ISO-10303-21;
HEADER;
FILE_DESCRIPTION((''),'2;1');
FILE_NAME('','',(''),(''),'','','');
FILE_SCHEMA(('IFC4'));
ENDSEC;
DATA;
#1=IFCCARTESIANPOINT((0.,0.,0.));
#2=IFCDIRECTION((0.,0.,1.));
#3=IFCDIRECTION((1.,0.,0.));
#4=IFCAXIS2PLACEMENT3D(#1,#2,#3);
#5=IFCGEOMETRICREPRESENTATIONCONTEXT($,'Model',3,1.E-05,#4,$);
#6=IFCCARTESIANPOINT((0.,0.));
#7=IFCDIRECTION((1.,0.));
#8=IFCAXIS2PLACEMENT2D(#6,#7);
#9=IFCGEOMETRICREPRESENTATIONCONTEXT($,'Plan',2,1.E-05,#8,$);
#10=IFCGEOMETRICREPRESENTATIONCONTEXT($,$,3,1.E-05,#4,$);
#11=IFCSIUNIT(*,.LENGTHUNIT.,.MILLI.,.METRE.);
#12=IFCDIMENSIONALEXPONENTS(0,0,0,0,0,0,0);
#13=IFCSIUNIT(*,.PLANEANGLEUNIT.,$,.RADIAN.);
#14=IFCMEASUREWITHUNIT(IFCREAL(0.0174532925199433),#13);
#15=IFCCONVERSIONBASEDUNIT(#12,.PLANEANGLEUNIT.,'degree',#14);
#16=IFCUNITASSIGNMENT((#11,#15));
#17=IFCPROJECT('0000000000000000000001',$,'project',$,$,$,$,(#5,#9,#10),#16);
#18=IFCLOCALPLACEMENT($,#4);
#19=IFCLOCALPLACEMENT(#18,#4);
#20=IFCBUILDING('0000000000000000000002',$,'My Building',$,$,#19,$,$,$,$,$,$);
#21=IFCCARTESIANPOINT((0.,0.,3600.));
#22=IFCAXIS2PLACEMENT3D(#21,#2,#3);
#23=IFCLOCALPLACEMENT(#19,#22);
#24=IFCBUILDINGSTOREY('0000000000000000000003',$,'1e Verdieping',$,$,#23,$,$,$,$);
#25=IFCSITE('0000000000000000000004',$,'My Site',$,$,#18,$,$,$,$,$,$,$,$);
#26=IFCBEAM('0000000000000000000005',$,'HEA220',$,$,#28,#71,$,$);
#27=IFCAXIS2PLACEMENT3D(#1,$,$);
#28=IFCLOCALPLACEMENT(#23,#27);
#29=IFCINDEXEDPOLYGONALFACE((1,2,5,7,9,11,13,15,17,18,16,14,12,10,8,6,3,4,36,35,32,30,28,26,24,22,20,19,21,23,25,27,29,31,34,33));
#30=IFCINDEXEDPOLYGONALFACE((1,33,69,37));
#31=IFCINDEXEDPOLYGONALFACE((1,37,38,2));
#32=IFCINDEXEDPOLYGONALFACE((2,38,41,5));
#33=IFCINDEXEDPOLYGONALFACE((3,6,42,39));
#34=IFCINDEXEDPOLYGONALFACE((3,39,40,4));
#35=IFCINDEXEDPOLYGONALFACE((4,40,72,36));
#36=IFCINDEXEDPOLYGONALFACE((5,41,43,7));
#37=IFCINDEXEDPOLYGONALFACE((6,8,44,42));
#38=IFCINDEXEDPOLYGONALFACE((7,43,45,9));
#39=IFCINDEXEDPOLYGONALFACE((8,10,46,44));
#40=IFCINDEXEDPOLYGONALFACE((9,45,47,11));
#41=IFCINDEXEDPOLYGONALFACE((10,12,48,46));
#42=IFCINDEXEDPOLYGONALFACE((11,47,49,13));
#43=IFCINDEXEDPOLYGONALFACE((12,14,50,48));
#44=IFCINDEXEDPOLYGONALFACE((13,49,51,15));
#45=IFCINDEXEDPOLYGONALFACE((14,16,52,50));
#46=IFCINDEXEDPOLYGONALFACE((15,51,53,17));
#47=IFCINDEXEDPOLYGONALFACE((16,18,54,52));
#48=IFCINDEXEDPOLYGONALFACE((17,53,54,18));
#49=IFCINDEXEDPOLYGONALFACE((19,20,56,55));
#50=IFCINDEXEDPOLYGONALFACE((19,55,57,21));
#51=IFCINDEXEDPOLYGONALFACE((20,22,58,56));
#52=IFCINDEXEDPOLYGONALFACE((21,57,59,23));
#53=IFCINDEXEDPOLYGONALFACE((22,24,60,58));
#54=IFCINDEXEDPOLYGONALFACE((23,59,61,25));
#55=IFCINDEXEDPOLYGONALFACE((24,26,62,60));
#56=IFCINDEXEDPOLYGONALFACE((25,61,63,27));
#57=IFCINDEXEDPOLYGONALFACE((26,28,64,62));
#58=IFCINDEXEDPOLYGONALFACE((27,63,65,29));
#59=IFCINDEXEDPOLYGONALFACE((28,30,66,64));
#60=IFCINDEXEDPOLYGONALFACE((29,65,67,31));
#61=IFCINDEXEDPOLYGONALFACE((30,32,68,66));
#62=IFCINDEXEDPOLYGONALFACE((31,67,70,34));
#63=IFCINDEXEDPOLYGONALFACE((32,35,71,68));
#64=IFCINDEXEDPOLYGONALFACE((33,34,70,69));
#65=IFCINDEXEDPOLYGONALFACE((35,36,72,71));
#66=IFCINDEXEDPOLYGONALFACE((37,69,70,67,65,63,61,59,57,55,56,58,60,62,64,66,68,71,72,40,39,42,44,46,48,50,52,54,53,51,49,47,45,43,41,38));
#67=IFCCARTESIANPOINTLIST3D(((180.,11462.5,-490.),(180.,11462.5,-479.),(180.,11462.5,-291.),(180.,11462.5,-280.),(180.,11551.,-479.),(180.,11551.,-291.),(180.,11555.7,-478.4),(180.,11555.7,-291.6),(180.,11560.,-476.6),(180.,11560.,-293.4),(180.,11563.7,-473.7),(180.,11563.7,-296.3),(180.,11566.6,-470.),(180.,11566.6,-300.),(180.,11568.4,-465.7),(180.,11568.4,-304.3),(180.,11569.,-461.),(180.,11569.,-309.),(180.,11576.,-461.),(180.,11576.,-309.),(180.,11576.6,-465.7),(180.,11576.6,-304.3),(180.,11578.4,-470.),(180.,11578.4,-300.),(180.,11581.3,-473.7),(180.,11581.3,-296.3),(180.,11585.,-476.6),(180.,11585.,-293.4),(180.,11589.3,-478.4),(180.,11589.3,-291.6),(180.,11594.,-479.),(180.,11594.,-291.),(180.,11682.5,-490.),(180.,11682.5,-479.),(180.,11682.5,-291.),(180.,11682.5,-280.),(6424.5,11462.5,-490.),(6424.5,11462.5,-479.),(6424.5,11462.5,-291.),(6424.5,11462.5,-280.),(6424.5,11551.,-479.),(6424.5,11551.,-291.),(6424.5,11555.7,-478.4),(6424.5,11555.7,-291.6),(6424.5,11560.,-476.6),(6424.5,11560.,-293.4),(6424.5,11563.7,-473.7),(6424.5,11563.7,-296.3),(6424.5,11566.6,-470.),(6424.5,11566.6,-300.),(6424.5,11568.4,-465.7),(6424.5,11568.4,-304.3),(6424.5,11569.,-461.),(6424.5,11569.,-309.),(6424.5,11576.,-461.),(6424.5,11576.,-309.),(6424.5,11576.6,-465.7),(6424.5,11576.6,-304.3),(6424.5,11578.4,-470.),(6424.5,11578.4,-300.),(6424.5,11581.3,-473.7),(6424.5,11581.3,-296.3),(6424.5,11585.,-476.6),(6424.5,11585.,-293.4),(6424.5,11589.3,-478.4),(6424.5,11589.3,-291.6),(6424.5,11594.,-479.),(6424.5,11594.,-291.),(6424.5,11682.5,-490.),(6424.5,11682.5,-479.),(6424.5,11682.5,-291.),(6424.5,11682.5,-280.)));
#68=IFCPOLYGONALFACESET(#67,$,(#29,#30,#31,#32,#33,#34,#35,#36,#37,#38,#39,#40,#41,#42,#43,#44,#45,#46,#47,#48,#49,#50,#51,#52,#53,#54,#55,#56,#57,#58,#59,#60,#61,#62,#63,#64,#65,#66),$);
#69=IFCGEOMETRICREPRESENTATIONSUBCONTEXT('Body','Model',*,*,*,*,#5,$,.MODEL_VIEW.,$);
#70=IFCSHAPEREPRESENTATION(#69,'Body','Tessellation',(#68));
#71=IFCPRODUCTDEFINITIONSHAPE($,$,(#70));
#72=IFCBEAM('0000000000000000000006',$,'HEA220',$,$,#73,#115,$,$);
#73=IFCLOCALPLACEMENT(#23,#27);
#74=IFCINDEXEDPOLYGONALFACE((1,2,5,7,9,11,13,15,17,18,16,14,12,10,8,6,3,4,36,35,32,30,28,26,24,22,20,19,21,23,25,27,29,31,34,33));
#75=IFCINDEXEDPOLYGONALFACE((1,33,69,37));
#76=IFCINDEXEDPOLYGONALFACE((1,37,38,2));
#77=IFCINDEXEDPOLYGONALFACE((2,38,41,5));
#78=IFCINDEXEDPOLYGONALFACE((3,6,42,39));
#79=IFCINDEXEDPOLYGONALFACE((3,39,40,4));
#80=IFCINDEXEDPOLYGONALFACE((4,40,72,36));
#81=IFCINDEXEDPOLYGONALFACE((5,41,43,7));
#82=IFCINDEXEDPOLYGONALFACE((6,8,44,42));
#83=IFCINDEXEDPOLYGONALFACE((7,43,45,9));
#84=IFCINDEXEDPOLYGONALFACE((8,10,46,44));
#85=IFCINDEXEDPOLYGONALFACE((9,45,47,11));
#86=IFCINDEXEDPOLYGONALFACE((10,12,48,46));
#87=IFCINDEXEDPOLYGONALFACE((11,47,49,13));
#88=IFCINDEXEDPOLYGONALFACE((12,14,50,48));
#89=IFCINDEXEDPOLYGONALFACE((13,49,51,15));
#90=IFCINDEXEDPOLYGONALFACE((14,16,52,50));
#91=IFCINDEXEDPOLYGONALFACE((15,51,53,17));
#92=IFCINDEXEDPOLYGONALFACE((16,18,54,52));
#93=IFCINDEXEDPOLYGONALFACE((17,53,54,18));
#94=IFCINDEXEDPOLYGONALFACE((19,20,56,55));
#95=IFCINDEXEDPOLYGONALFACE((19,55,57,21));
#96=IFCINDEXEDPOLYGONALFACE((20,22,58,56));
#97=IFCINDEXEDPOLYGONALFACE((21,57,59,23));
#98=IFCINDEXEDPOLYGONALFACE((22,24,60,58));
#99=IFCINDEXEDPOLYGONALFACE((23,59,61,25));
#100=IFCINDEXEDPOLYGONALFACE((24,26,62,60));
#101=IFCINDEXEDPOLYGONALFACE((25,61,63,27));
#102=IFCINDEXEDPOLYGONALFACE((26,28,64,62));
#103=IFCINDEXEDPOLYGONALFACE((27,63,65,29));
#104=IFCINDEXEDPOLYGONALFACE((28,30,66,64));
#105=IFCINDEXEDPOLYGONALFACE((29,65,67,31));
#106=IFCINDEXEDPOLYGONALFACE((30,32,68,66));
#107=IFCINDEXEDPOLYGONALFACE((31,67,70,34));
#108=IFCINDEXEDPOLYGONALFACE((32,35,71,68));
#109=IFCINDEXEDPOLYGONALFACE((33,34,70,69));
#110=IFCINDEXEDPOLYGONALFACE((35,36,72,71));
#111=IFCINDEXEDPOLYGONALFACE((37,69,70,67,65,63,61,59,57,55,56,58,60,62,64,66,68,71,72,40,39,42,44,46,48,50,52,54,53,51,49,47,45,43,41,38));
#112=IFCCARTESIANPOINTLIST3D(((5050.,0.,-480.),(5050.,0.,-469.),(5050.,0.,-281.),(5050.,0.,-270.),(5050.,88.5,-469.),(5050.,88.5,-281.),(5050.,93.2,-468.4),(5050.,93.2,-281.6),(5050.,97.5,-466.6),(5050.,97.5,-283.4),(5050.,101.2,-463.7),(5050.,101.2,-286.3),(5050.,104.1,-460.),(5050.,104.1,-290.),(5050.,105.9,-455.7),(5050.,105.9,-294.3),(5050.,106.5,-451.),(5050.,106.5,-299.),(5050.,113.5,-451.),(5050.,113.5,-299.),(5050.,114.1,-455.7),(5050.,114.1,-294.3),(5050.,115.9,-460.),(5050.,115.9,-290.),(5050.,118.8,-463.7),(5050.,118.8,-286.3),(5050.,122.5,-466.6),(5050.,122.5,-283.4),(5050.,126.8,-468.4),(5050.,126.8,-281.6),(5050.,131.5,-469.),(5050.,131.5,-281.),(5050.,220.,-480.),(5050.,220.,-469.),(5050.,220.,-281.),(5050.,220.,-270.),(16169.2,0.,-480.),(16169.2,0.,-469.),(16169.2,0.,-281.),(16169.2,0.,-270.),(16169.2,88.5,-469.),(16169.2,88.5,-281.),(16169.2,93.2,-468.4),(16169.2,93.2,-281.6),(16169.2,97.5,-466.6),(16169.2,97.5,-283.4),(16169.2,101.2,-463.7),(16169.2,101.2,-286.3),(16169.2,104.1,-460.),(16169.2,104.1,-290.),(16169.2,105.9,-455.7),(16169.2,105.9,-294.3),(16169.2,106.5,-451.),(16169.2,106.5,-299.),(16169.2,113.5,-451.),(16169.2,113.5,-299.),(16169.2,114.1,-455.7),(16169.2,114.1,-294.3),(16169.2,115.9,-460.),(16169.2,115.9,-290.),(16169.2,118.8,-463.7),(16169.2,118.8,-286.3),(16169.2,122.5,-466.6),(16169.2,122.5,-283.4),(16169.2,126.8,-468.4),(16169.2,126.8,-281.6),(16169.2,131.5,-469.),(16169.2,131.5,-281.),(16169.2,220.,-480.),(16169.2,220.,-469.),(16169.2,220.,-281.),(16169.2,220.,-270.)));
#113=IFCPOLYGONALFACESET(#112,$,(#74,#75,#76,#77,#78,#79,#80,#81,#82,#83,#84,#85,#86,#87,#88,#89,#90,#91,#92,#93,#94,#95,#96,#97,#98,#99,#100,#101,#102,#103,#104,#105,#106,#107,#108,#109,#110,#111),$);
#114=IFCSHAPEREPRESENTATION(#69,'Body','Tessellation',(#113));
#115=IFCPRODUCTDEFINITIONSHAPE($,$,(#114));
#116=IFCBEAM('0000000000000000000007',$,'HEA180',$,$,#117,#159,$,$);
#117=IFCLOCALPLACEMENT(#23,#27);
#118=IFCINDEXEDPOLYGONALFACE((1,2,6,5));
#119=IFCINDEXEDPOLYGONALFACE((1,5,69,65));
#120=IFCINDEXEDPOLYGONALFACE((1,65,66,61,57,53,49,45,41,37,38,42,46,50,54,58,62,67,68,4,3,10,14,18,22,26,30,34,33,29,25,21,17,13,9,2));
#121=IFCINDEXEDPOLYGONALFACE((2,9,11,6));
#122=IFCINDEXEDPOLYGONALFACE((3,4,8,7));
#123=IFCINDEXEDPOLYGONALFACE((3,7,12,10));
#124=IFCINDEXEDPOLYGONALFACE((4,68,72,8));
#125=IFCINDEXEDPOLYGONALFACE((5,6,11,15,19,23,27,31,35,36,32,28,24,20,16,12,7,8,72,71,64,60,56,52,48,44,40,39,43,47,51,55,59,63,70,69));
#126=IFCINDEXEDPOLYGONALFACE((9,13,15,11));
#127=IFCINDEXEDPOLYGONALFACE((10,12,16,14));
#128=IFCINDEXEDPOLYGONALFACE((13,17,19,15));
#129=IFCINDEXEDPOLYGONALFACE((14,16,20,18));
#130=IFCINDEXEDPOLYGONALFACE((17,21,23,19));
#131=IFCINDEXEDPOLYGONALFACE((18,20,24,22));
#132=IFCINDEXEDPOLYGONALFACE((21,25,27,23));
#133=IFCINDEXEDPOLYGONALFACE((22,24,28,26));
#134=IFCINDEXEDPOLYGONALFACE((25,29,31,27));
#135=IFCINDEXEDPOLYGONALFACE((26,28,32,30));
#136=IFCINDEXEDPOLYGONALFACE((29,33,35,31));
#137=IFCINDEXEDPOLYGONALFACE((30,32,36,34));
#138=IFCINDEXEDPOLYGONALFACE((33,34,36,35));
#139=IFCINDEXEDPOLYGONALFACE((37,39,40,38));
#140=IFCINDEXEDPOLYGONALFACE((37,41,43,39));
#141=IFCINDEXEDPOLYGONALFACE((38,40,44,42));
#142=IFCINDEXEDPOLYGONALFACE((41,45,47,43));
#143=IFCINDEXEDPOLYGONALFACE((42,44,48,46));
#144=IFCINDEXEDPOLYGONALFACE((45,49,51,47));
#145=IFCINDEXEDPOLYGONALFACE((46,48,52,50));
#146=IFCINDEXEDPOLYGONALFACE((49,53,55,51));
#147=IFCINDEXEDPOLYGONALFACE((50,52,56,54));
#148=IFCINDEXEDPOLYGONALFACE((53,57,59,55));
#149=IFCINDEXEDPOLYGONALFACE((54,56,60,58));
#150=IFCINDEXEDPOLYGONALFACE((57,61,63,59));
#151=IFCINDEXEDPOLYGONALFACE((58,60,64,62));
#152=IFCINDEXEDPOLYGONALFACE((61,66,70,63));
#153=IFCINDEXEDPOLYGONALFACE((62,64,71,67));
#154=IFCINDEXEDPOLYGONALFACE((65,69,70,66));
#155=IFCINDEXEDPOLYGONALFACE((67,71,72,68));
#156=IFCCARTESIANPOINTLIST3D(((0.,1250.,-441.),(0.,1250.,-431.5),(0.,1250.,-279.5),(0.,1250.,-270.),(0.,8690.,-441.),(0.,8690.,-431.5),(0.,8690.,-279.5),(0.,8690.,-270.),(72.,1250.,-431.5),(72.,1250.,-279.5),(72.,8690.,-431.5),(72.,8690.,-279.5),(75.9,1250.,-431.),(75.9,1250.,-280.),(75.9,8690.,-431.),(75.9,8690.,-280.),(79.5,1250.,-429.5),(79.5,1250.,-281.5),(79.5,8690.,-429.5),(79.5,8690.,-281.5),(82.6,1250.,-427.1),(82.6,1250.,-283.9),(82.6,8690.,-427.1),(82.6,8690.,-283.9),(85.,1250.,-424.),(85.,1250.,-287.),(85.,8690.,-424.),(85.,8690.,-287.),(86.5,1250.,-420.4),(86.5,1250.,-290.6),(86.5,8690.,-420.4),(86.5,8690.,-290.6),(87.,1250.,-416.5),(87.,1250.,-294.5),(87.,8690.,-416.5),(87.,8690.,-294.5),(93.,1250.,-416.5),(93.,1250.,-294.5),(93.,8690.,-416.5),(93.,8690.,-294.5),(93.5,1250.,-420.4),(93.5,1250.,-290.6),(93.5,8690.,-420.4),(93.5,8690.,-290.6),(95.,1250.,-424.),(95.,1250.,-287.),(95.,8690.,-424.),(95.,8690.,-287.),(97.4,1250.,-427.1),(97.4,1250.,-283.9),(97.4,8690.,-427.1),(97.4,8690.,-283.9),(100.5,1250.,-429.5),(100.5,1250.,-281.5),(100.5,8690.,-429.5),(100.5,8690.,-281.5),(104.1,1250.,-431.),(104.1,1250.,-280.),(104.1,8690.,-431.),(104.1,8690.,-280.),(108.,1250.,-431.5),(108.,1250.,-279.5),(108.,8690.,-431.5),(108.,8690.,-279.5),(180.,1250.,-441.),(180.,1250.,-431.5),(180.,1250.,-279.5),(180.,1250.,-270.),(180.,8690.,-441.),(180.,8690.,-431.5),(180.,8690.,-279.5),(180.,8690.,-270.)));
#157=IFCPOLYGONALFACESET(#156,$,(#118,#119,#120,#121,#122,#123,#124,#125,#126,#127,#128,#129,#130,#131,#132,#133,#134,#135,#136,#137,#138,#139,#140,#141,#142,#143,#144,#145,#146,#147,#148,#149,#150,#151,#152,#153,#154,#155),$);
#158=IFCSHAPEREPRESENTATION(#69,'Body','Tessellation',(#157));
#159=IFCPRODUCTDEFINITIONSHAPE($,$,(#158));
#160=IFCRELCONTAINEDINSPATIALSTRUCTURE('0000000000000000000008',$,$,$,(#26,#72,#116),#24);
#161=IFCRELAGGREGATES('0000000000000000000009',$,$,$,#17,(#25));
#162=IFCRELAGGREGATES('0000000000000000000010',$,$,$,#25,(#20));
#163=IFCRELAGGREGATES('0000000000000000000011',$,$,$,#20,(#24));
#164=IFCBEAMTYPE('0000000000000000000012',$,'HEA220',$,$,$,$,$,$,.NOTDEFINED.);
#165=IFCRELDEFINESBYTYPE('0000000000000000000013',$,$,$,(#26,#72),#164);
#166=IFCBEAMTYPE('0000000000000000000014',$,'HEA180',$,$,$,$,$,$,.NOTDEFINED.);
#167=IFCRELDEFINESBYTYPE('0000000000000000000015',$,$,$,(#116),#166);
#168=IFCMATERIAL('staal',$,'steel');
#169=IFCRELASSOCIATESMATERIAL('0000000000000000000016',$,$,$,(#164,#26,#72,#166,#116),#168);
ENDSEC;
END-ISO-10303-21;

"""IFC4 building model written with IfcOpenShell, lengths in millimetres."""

from ifc_helpers import new_model, entity, si_unit, converted_unit, frame, origin_with_axes, origin_2d_with_axis, place, context, subcontext, project, spatial, i_section, extrude, material, material_profile, profile_set, profile_usage, type_object, element, save


model = new_model("IFC4")

# Units and contexts
model_context = context("Model", 3, precision=1e-05, world=origin_with_axes())
plan_context = context("Plan", 2, precision=1e-05, world=origin_2d_with_axis())
context_of_model = context(None, 3, precision=1e-05, world=origin_with_axes())
body_context = subcontext(model_context, "Body", "Model", "MODEL_VIEW")
ifc_project = project(units=[si_unit("LENGTHUNIT", "METRE", prefix="MILLI"), converted_unit("PLANEANGLEUNIT", "degree", entity("IfcReal", 0.0174532925199433), si_unit("PLANEANGLEUNIT", "RADIAN"), dimensions=[0, 0, 0, 0, 0, 0, 0])], contexts=[model_context, plan_context, context_of_model])

# Site, building, storey
site_placement = place(None, origin_with_axes())
site = spatial("IfcSite", under=ifc_project, at=site_placement, Name="My Site")
building_placement = place(site_placement, origin_with_axes())
building = spatial("IfcBuilding", under=site, at=building_placement, Name="My Building")
storey_placement = place(building_placement, frame((0.0, 0.0, 3600.0), z_axis=(0.0, 0.0, 1.0), x_axis=(1.0, 0.0, 0.0)))
storey = spatial("IfcBuildingStorey", under=building, at=storey_placement, Name="1e Verdieping")

# Shared definitions
ifc_material = material(Name="staal", Category="steel")

# Beams
ifc_material_profile_1 = material_profile(ifc_material, i_section(OverallWidth=220.0, OverallDepth=210.0, WebThickness=7.0, FlangeThickness=11.0, FilletRadius=18.0))
ifc_profile_set_1 = profile_set([ifc_material_profile_1], Name="HEA220")
beam_type_1 = type_object("IfcBeamType", Name="HEA220", PredefinedType="NOTDEFINED", material=ifc_profile_set_1)
ifc_profile_usage_1 = profile_usage(ifc_profile_set_1)
beam_1_placement = place(storey_placement, frame((180.0, 11572.5, -385.0), z_axis=(1.0, 0.0, 0.0), x_axis=(0.0, 1.0, 0.0)))
element("IfcBeam", 1, at=beam_1_placement, inside=storey, type_object=beam_type_1, material=ifc_profile_usage_1, Name="HEA220", context=body_context, shape_type="SweptSolid", body=[
    extrude(i_section(OverallWidth=220.0, OverallDepth=210.0, WebThickness=7.0, FlangeThickness=11.0, FilletRadius=18.0), origin_with_axes(), (0.0, 0.0, 1.0), 6244.5),
])
ifc_profile_usage_2 = profile_usage(ifc_profile_set_1)
beam_2_placement = place(storey_placement, frame((5050.0, 110.0, -375.0), z_axis=(1.0, 0.0, 0.0), x_axis=(0.0, 1.0, 0.0)))
element("IfcBeam", 2, at=beam_2_placement, inside=storey, type_object=beam_type_1, material=ifc_profile_usage_2, Name="HEA220", context=body_context, shape_type="SweptSolid", body=[
    extrude(i_section(OverallWidth=220.0, OverallDepth=210.0, WebThickness=7.0, FlangeThickness=11.0, FilletRadius=18.0), origin_with_axes(), (0.0, 0.0, 1.0), 11119.2),
])
ifc_material_profile_2 = material_profile(ifc_material, i_section(OverallWidth=180.0, OverallDepth=171.0, WebThickness=6.0, FlangeThickness=9.5, FilletRadius=15.0))
ifc_profile_set_2 = profile_set([ifc_material_profile_2], Name="HEA180")
ifc_profile_usage_3 = profile_usage(ifc_profile_set_2, cardinal=5)
beam_type_2 = type_object("IfcBeamType", Name="HEA180", PredefinedType="NOTDEFINED", material=ifc_profile_set_2)
beam_3_placement = place(storey_placement, frame((90.0, 1250.0, -355.5), z_axis=(0.0, 1.0, 0.0), x_axis=(-1.0, 0.0, 0.0)))
element("IfcBeam", 3, at=beam_3_placement, inside=storey, type_object=beam_type_2, material=ifc_profile_usage_3, Name="HEA180", context=body_context, shape_type="SweptSolid", body=[
    extrude(i_section(OverallWidth=180.0, OverallDepth=171.0, WebThickness=6.0, FlangeThickness=9.5, FilletRadius=15.0), origin_with_axes(), (0.0, 0.0, 1.0), 7440.0),
])

save(model, "model.ifc")
